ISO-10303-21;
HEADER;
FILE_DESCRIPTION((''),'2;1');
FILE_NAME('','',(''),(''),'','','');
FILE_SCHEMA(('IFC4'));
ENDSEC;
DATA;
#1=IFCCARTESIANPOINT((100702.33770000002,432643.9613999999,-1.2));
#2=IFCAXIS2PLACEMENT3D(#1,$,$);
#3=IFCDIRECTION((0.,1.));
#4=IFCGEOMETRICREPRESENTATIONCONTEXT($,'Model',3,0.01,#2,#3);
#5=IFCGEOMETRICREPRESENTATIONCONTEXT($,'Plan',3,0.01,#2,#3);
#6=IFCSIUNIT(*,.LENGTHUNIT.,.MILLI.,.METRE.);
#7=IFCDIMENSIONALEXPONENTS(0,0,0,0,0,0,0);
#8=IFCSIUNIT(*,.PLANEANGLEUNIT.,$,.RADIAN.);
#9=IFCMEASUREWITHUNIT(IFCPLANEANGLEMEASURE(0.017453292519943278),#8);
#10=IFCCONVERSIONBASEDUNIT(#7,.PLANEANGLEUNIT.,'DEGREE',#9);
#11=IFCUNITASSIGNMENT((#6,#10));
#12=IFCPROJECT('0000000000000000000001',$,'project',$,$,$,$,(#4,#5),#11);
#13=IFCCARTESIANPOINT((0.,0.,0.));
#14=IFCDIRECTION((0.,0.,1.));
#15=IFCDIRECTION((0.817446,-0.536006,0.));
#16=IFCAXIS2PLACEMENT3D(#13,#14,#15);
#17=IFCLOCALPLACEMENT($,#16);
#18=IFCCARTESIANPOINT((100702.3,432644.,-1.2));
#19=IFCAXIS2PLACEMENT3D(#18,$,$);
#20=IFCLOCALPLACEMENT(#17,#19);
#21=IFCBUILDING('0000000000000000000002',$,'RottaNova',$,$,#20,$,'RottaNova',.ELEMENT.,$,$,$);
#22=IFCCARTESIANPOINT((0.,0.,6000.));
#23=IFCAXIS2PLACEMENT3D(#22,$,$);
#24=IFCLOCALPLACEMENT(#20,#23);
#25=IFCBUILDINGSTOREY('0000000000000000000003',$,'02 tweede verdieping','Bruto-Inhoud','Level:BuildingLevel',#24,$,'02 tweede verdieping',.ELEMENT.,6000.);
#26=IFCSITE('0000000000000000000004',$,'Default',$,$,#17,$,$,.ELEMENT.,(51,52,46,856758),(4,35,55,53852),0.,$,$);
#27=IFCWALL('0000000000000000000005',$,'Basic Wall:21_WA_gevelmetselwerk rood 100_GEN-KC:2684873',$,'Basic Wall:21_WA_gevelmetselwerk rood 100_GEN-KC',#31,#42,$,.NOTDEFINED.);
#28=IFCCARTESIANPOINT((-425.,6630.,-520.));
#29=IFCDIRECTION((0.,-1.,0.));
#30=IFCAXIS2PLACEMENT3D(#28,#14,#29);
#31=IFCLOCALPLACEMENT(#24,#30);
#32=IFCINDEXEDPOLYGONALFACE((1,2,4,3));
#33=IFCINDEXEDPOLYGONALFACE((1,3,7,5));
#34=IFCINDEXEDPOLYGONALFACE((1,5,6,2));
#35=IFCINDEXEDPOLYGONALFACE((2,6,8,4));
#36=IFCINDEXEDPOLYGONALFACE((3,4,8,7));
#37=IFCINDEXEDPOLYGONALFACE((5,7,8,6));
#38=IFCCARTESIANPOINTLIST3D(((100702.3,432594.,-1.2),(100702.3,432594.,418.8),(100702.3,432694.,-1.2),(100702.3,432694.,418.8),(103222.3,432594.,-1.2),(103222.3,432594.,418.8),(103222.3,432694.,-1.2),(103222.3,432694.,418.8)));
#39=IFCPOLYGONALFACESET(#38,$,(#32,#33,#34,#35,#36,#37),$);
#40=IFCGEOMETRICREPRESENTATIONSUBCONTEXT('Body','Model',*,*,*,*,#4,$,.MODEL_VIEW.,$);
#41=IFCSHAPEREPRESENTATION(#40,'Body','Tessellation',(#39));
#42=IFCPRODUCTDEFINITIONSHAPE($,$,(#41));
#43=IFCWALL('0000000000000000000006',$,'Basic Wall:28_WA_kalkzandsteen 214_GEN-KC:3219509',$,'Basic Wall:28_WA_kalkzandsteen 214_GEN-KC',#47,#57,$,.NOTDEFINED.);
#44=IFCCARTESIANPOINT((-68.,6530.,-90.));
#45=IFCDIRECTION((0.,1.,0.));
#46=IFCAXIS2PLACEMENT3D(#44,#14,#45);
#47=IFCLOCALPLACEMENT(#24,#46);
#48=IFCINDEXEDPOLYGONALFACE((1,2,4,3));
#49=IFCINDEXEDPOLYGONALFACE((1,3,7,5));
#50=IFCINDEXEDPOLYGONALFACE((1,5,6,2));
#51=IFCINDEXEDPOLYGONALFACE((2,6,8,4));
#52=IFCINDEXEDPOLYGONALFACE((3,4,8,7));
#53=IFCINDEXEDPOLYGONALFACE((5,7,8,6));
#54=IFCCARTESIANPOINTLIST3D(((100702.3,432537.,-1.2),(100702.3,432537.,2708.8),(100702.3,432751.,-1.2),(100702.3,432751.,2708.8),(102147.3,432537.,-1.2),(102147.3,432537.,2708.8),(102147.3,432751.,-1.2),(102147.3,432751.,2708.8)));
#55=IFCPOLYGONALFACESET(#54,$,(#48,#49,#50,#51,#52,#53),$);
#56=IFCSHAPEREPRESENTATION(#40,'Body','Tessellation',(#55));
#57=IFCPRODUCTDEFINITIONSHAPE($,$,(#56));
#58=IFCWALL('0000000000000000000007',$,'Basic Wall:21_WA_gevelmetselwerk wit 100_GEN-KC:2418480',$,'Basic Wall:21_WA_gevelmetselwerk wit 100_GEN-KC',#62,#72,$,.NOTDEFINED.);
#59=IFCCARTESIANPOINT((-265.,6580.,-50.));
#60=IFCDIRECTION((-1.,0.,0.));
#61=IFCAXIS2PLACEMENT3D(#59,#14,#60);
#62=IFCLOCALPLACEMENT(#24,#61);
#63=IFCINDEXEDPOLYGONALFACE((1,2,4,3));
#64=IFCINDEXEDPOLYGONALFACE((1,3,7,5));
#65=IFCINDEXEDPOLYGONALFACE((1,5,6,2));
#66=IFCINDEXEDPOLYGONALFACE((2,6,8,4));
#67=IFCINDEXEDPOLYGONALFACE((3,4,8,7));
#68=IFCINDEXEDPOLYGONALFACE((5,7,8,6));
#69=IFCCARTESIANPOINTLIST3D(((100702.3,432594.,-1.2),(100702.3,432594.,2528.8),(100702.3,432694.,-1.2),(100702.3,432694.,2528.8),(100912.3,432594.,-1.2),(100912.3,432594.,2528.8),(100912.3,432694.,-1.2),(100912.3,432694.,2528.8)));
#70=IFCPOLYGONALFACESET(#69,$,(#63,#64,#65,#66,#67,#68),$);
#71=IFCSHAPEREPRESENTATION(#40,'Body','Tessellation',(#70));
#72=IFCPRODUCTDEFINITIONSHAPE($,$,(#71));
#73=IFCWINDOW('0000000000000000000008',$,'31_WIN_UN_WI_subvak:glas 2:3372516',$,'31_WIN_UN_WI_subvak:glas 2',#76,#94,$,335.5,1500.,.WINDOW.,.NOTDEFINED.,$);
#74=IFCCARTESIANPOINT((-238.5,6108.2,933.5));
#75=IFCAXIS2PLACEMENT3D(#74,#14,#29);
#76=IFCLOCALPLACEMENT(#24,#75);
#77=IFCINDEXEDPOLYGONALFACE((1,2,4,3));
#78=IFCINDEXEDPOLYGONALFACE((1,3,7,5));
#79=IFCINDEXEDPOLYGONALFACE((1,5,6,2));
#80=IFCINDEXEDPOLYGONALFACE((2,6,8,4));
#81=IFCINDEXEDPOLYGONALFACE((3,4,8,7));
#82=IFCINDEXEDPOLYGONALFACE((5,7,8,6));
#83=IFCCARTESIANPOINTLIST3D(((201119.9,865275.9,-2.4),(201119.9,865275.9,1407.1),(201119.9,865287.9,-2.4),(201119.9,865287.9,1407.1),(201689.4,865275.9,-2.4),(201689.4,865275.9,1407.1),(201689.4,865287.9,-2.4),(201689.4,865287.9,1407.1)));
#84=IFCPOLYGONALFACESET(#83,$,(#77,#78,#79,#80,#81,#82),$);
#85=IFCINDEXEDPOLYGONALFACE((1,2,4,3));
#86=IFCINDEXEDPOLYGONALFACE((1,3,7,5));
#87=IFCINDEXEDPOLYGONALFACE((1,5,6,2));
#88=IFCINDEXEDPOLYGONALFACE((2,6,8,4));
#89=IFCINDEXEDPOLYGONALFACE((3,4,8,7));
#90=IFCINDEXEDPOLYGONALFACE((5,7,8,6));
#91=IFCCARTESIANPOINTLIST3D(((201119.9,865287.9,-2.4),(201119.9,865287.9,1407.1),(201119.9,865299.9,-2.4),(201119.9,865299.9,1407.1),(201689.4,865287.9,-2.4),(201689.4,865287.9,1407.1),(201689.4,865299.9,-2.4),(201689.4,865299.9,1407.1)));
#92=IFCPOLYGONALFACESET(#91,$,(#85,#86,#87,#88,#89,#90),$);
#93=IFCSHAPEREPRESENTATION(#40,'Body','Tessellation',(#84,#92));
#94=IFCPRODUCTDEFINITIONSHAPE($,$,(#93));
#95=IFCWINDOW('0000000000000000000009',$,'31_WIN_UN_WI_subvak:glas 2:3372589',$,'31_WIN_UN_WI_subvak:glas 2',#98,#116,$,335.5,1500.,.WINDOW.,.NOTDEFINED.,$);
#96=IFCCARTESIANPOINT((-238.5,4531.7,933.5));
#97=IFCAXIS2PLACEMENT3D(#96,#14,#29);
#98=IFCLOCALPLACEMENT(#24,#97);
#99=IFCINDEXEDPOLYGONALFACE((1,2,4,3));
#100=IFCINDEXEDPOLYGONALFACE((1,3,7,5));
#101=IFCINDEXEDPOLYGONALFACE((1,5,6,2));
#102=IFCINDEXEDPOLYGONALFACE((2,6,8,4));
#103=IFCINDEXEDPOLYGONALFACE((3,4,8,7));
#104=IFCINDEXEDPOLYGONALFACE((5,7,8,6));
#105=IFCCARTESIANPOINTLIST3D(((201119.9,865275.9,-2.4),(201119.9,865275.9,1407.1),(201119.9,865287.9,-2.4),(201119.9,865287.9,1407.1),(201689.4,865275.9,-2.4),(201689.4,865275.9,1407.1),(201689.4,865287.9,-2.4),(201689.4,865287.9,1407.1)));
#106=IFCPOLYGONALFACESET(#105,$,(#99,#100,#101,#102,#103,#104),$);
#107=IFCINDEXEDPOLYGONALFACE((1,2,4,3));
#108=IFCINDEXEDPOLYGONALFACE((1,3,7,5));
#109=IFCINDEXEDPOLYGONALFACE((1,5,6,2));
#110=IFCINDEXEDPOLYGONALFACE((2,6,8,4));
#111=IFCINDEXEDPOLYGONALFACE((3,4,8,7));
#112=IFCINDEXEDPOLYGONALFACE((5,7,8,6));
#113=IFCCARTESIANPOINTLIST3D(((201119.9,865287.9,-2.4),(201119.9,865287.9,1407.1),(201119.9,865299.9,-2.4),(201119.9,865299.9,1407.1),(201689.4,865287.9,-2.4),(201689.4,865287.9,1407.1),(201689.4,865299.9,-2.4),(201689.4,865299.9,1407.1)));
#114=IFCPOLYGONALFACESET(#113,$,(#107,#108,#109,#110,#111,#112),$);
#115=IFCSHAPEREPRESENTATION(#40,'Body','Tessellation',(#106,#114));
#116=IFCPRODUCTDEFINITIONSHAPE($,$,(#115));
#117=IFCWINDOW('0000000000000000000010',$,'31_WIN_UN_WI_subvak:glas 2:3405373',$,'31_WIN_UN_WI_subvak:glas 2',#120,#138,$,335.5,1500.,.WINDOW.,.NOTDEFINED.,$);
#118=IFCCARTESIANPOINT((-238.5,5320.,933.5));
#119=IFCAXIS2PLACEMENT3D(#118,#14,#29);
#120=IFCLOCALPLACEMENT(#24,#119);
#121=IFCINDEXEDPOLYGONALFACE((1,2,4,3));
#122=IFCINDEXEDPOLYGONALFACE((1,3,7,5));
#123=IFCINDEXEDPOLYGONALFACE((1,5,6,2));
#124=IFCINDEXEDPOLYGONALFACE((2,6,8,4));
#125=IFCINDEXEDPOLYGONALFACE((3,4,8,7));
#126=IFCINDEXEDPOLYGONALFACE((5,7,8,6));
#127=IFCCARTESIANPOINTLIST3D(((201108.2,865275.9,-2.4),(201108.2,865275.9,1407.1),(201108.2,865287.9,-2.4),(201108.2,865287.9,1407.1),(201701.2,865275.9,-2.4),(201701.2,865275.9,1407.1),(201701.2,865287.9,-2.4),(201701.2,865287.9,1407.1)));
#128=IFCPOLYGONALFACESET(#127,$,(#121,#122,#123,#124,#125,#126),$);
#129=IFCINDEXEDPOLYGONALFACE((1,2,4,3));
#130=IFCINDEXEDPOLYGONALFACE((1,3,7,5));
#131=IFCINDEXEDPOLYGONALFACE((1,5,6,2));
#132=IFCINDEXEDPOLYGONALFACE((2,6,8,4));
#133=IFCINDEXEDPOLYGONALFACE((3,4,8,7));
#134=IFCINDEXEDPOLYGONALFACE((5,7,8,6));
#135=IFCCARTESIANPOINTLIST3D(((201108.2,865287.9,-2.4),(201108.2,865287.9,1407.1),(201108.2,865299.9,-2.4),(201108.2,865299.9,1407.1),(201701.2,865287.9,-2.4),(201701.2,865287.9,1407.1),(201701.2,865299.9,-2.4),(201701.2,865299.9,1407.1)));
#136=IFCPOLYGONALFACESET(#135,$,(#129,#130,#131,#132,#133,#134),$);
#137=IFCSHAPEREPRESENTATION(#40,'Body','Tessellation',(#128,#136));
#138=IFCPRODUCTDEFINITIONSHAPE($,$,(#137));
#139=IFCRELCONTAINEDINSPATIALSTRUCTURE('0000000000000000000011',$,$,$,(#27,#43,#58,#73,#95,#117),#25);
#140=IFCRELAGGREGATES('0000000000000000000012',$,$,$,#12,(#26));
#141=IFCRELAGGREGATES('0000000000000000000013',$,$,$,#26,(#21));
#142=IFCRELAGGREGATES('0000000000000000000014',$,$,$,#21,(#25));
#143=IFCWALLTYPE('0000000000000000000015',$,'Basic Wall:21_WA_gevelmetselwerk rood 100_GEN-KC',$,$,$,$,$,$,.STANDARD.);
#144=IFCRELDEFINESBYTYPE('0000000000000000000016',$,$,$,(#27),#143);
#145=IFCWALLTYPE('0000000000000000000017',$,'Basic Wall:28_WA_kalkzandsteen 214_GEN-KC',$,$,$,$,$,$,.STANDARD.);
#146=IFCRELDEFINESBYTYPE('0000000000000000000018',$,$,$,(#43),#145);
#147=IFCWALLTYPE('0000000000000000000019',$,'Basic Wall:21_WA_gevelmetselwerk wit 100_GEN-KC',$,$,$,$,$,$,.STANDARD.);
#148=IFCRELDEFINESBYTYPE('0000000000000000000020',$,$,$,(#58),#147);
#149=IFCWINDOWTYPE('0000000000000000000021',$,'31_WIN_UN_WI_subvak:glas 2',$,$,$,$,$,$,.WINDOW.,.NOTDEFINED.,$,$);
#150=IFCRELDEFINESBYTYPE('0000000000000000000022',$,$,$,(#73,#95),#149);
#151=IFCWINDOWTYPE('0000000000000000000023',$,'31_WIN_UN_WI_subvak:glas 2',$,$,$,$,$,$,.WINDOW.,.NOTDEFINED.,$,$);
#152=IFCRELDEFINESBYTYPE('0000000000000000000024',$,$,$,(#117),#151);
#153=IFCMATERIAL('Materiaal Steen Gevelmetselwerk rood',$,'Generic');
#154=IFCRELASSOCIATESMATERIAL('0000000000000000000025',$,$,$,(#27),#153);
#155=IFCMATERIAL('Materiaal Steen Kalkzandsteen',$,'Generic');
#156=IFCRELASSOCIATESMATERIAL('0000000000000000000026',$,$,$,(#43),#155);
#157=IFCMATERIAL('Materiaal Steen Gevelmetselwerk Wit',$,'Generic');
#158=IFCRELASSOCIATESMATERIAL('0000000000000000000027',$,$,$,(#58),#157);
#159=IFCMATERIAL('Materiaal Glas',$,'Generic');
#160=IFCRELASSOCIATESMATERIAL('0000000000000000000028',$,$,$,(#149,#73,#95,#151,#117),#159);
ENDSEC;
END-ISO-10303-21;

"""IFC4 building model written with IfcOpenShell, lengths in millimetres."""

from ifc_helpers import new_model, entity, si_unit, converted_unit, direction, frame, place, context, subcontext, project, spatial, indexed_curve, outline, extrude, source, transform, mapped, material, type_object, type_shapes, element, save


model = new_model("IFC4")

# Units and contexts
model_context = context("Model", 3, precision=0.01, world=frame((100702.33770000002, 432643.9613999999, -1.2)), true_north=direction((0.0, 1.0)))
plan_context = context("Plan", 3, precision=0.01, world=frame((100702.33770000002, 432643.9613999999, -1.2)), true_north=direction((0.0, 1.0)))
body_context = subcontext(model_context, "Body", "Model", "MODEL_VIEW")
ifc_project = project(units=[si_unit("LENGTHUNIT", "METRE", prefix="MILLI"), converted_unit("PLANEANGLEUNIT", "DEGREE", entity("IfcPlaneAngleMeasure", 0.017453292519943278), si_unit("PLANEANGLEUNIT", "RADIAN"), dimensions=[0, 0, 0, 0, 0, 0, 0])], contexts=[model_context, plan_context])

# Site, building, storey
site_placement = place(None, frame((0.0, 0.0, 0.0), z_axis=(0.0, 0.0, 1.0), x_axis=(0.817446, -0.536006, 0.0)))
site = spatial("IfcSite", under=ifc_project, at=site_placement, Name="Default", CompositionType="ELEMENT", RefLatitude=(51, 52, 46, 856758), RefLongitude=(4, 35, 55, 53852), RefElevation=0.0)
building_placement = place(site_placement, frame((100702.3, 432644.0, -1.2)))
building = spatial("IfcBuilding", under=site, at=building_placement, Name="RottaNova", LongName="RottaNova", CompositionType="ELEMENT")
storey_placement = place(building_placement, frame((0.0, 0.0, 6000.0)))
storey = spatial("IfcBuildingStorey", under=building, at=storey_placement, Name="02 tweede verdieping", Description="Bruto-Inhoud", ObjectType="Level:BuildingLevel", LongName="02 tweede verdieping", CompositionType="ELEMENT", Elevation=6000.0)

# Shared definitions
ifc_material_1 = material(Name="Materiaal Glas", Category="Generic")

# Walls
ifc_material_2 = material(Name="Materiaal Steen Gevelmetselwerk rood", Category="Generic")
wall_type_1 = type_object("IfcWallType", Name="Basic Wall:21_WA_gevelmetselwerk rood 100_GEN-KC", PredefinedType="STANDARD")
wall_1_placement = place(storey_placement, frame((-425.0, 6630.0, -520.0), z_axis=(0.0, 0.0, 1.0), x_axis=(0.0, -1.0, 0.0)))
element("IfcWall", 1, at=wall_1_placement, inside=storey, type_object=wall_type_1, material=ifc_material_2, Name="Basic Wall:21_WA_gevelmetselwerk rood 100_GEN-KC:2684873", ObjectType="Basic Wall:21_WA_gevelmetselwerk rood 100_GEN-KC", PredefinedType="NOTDEFINED", context=body_context, shape_type="SweptSolid", body=[
    extrude(outline(indexed_curve([(2520.0, 50.0), (0.0, 50.0), (0.0, -50.0), (2520.0, -50.0), (2520.0, 50.0)], self_intersect=False)), frame((100702.3, 432644.0, -1.2)), (0.0, 0.0, 1.0), 420.0),
])
ifc_material_3 = material(Name="Materiaal Steen Kalkzandsteen", Category="Generic")
wall_type_2 = type_object("IfcWallType", Name="Basic Wall:28_WA_kalkzandsteen 214_GEN-KC", PredefinedType="STANDARD")
wall_2_placement = place(storey_placement, frame((-68.0, 6530.0, -90.0), z_axis=(0.0, 0.0, 1.0), x_axis=(0.0, 1.0, 0.0)))
element("IfcWall", 2, at=wall_2_placement, inside=storey, type_object=wall_type_2, material=ifc_material_3, Name="Basic Wall:28_WA_kalkzandsteen 214_GEN-KC:3219509", ObjectType="Basic Wall:28_WA_kalkzandsteen 214_GEN-KC", PredefinedType="NOTDEFINED", context=body_context, shape_type="SweptSolid", body=[
    extrude(outline(indexed_curve([(1445.0, 107.0), (0.0, 107.0), (0.0, -107.0), (1445.0, -107.0), (1445.0, 107.0)], self_intersect=False)), frame((100702.3, 432644.0, -1.2)), (0.0, 0.0, 1.0), 2710.0),
])
ifc_material_4 = material(Name="Materiaal Steen Gevelmetselwerk Wit", Category="Generic")
wall_type_3 = type_object("IfcWallType", Name="Basic Wall:21_WA_gevelmetselwerk wit 100_GEN-KC", PredefinedType="STANDARD")
wall_3_placement = place(storey_placement, frame((-265.0, 6580.0, -50.0), z_axis=(0.0, 0.0, 1.0), x_axis=(-1.0, 0.0, 0.0)))
element("IfcWall", 3, at=wall_3_placement, inside=storey, type_object=wall_type_3, material=ifc_material_4, Name="Basic Wall:21_WA_gevelmetselwerk wit 100_GEN-KC:2418480", ObjectType="Basic Wall:21_WA_gevelmetselwerk wit 100_GEN-KC", PredefinedType="NOTDEFINED", context=body_context, shape_type="SweptSolid", body=[
    extrude(outline(indexed_curve([(210.0, 50.0), (0.0, 50.0), (0.0, -50.0), (210.0, -50.0), (210.0, 50.0)], self_intersect=False)), frame((100702.3, 432644.0, -1.2)), (0.0, 0.0, 1.0), 2530.0),
])

# Windows
window_type_1 = type_object("IfcWindowType", Name="31_WIN_UN_WI_subvak:glas 2", PartitioningType="NOTDEFINED", PredefinedType="WINDOW", material=ifc_material_1)
shared_shape_1 = source(frame((100702.3, 432644.0, -1.2)), body_context, "Body", "SweptSolid", [
    extrude(outline(indexed_curve([(-284.7, -6.0), (284.7, -6.0), (284.7, 6.0), (-284.7, 6.0), (-284.7, -6.0)], self_intersect=False)), frame((0.0, -6.0, 0.0)), (0.0, 0.0, 1.0), 1409.5),
    extrude(outline(indexed_curve([(-284.8, -6.0), (284.8, -6.0), (284.8, 6.0), (-284.8, 6.0), (-284.8, -6.0)], self_intersect=False)), frame((0.0, 6.0, 0.0)), (0.0, 0.0, 1.0), 1409.5),
])
type_shapes(window_type_1, [shared_shape_1])
for number, where, z_axis, x_axis, name in (
    (4, (-238.5, 6108.2, 933.5), (0.0, 0.0, 1.0), (0.0, -1.0, 0.0), "31_WIN_UN_WI_subvak:glas 2:3372516"),
    (5, (-238.5, 4531.7, 933.5), (0.0, 0.0, 1.0), (0.0, -1.0, 0.0), "31_WIN_UN_WI_subvak:glas 2:3372589"),
):
    element("IfcWindow", number, at=place(storey_placement, frame(where, z_axis=z_axis, x_axis=x_axis)), inside=storey, type_object=window_type_1, material=ifc_material_1, Name=name, ObjectType="31_WIN_UN_WI_subvak:glas 2", OverallHeight=335.5, OverallWidth=1500.0, PartitioningType="NOTDEFINED", PredefinedType="WINDOW", context=body_context, shape_type="MappedRepresentation", body=[
        mapped(shared_shape_1, transform((100702.3, 432644.0, -1.2), scale=1.0)),
    ])
window_type_2 = type_object("IfcWindowType", Name="31_WIN_UN_WI_subvak:glas 2", PartitioningType="NOTDEFINED", PredefinedType="WINDOW", material=ifc_material_1)
shared_shape_2 = source(frame((100702.3, 432644.0, -1.2)), body_context, "Body", "SweptSolid", [
    extrude(outline(indexed_curve([(-296.5, -6.0), (296.5, -6.0), (296.5, 6.0), (-296.5, 6.0), (-296.5, -6.0)], self_intersect=False)), frame((0.0, -6.0, 0.0)), (0.0, 0.0, 1.0), 1409.5),
    extrude(outline(indexed_curve([(-296.5, -6.0), (296.5, -6.0), (296.5, 6.0), (-296.5, 6.0), (-296.5, -6.0)], self_intersect=False)), frame((0.0, 6.0, 0.0)), (0.0, 0.0, 1.0), 1409.5),
])
type_shapes(window_type_2, [shared_shape_2])
window_1_placement = place(storey_placement, frame((-238.5, 5320.0, 933.5), z_axis=(0.0, 0.0, 1.0), x_axis=(0.0, -1.0, 0.0)))
element("IfcWindow", 6, at=window_1_placement, inside=storey, type_object=window_type_2, material=ifc_material_1, Name="31_WIN_UN_WI_subvak:glas 2:3405373", ObjectType="31_WIN_UN_WI_subvak:glas 2", OverallHeight=335.5, OverallWidth=1500.0, PartitioningType="NOTDEFINED", PredefinedType="WINDOW", context=body_context, shape_type="MappedRepresentation", body=[
    mapped(shared_shape_2, transform((100702.3, 432644.0, -1.2), scale=1.0)),
])

save(model, "model.ifc")
